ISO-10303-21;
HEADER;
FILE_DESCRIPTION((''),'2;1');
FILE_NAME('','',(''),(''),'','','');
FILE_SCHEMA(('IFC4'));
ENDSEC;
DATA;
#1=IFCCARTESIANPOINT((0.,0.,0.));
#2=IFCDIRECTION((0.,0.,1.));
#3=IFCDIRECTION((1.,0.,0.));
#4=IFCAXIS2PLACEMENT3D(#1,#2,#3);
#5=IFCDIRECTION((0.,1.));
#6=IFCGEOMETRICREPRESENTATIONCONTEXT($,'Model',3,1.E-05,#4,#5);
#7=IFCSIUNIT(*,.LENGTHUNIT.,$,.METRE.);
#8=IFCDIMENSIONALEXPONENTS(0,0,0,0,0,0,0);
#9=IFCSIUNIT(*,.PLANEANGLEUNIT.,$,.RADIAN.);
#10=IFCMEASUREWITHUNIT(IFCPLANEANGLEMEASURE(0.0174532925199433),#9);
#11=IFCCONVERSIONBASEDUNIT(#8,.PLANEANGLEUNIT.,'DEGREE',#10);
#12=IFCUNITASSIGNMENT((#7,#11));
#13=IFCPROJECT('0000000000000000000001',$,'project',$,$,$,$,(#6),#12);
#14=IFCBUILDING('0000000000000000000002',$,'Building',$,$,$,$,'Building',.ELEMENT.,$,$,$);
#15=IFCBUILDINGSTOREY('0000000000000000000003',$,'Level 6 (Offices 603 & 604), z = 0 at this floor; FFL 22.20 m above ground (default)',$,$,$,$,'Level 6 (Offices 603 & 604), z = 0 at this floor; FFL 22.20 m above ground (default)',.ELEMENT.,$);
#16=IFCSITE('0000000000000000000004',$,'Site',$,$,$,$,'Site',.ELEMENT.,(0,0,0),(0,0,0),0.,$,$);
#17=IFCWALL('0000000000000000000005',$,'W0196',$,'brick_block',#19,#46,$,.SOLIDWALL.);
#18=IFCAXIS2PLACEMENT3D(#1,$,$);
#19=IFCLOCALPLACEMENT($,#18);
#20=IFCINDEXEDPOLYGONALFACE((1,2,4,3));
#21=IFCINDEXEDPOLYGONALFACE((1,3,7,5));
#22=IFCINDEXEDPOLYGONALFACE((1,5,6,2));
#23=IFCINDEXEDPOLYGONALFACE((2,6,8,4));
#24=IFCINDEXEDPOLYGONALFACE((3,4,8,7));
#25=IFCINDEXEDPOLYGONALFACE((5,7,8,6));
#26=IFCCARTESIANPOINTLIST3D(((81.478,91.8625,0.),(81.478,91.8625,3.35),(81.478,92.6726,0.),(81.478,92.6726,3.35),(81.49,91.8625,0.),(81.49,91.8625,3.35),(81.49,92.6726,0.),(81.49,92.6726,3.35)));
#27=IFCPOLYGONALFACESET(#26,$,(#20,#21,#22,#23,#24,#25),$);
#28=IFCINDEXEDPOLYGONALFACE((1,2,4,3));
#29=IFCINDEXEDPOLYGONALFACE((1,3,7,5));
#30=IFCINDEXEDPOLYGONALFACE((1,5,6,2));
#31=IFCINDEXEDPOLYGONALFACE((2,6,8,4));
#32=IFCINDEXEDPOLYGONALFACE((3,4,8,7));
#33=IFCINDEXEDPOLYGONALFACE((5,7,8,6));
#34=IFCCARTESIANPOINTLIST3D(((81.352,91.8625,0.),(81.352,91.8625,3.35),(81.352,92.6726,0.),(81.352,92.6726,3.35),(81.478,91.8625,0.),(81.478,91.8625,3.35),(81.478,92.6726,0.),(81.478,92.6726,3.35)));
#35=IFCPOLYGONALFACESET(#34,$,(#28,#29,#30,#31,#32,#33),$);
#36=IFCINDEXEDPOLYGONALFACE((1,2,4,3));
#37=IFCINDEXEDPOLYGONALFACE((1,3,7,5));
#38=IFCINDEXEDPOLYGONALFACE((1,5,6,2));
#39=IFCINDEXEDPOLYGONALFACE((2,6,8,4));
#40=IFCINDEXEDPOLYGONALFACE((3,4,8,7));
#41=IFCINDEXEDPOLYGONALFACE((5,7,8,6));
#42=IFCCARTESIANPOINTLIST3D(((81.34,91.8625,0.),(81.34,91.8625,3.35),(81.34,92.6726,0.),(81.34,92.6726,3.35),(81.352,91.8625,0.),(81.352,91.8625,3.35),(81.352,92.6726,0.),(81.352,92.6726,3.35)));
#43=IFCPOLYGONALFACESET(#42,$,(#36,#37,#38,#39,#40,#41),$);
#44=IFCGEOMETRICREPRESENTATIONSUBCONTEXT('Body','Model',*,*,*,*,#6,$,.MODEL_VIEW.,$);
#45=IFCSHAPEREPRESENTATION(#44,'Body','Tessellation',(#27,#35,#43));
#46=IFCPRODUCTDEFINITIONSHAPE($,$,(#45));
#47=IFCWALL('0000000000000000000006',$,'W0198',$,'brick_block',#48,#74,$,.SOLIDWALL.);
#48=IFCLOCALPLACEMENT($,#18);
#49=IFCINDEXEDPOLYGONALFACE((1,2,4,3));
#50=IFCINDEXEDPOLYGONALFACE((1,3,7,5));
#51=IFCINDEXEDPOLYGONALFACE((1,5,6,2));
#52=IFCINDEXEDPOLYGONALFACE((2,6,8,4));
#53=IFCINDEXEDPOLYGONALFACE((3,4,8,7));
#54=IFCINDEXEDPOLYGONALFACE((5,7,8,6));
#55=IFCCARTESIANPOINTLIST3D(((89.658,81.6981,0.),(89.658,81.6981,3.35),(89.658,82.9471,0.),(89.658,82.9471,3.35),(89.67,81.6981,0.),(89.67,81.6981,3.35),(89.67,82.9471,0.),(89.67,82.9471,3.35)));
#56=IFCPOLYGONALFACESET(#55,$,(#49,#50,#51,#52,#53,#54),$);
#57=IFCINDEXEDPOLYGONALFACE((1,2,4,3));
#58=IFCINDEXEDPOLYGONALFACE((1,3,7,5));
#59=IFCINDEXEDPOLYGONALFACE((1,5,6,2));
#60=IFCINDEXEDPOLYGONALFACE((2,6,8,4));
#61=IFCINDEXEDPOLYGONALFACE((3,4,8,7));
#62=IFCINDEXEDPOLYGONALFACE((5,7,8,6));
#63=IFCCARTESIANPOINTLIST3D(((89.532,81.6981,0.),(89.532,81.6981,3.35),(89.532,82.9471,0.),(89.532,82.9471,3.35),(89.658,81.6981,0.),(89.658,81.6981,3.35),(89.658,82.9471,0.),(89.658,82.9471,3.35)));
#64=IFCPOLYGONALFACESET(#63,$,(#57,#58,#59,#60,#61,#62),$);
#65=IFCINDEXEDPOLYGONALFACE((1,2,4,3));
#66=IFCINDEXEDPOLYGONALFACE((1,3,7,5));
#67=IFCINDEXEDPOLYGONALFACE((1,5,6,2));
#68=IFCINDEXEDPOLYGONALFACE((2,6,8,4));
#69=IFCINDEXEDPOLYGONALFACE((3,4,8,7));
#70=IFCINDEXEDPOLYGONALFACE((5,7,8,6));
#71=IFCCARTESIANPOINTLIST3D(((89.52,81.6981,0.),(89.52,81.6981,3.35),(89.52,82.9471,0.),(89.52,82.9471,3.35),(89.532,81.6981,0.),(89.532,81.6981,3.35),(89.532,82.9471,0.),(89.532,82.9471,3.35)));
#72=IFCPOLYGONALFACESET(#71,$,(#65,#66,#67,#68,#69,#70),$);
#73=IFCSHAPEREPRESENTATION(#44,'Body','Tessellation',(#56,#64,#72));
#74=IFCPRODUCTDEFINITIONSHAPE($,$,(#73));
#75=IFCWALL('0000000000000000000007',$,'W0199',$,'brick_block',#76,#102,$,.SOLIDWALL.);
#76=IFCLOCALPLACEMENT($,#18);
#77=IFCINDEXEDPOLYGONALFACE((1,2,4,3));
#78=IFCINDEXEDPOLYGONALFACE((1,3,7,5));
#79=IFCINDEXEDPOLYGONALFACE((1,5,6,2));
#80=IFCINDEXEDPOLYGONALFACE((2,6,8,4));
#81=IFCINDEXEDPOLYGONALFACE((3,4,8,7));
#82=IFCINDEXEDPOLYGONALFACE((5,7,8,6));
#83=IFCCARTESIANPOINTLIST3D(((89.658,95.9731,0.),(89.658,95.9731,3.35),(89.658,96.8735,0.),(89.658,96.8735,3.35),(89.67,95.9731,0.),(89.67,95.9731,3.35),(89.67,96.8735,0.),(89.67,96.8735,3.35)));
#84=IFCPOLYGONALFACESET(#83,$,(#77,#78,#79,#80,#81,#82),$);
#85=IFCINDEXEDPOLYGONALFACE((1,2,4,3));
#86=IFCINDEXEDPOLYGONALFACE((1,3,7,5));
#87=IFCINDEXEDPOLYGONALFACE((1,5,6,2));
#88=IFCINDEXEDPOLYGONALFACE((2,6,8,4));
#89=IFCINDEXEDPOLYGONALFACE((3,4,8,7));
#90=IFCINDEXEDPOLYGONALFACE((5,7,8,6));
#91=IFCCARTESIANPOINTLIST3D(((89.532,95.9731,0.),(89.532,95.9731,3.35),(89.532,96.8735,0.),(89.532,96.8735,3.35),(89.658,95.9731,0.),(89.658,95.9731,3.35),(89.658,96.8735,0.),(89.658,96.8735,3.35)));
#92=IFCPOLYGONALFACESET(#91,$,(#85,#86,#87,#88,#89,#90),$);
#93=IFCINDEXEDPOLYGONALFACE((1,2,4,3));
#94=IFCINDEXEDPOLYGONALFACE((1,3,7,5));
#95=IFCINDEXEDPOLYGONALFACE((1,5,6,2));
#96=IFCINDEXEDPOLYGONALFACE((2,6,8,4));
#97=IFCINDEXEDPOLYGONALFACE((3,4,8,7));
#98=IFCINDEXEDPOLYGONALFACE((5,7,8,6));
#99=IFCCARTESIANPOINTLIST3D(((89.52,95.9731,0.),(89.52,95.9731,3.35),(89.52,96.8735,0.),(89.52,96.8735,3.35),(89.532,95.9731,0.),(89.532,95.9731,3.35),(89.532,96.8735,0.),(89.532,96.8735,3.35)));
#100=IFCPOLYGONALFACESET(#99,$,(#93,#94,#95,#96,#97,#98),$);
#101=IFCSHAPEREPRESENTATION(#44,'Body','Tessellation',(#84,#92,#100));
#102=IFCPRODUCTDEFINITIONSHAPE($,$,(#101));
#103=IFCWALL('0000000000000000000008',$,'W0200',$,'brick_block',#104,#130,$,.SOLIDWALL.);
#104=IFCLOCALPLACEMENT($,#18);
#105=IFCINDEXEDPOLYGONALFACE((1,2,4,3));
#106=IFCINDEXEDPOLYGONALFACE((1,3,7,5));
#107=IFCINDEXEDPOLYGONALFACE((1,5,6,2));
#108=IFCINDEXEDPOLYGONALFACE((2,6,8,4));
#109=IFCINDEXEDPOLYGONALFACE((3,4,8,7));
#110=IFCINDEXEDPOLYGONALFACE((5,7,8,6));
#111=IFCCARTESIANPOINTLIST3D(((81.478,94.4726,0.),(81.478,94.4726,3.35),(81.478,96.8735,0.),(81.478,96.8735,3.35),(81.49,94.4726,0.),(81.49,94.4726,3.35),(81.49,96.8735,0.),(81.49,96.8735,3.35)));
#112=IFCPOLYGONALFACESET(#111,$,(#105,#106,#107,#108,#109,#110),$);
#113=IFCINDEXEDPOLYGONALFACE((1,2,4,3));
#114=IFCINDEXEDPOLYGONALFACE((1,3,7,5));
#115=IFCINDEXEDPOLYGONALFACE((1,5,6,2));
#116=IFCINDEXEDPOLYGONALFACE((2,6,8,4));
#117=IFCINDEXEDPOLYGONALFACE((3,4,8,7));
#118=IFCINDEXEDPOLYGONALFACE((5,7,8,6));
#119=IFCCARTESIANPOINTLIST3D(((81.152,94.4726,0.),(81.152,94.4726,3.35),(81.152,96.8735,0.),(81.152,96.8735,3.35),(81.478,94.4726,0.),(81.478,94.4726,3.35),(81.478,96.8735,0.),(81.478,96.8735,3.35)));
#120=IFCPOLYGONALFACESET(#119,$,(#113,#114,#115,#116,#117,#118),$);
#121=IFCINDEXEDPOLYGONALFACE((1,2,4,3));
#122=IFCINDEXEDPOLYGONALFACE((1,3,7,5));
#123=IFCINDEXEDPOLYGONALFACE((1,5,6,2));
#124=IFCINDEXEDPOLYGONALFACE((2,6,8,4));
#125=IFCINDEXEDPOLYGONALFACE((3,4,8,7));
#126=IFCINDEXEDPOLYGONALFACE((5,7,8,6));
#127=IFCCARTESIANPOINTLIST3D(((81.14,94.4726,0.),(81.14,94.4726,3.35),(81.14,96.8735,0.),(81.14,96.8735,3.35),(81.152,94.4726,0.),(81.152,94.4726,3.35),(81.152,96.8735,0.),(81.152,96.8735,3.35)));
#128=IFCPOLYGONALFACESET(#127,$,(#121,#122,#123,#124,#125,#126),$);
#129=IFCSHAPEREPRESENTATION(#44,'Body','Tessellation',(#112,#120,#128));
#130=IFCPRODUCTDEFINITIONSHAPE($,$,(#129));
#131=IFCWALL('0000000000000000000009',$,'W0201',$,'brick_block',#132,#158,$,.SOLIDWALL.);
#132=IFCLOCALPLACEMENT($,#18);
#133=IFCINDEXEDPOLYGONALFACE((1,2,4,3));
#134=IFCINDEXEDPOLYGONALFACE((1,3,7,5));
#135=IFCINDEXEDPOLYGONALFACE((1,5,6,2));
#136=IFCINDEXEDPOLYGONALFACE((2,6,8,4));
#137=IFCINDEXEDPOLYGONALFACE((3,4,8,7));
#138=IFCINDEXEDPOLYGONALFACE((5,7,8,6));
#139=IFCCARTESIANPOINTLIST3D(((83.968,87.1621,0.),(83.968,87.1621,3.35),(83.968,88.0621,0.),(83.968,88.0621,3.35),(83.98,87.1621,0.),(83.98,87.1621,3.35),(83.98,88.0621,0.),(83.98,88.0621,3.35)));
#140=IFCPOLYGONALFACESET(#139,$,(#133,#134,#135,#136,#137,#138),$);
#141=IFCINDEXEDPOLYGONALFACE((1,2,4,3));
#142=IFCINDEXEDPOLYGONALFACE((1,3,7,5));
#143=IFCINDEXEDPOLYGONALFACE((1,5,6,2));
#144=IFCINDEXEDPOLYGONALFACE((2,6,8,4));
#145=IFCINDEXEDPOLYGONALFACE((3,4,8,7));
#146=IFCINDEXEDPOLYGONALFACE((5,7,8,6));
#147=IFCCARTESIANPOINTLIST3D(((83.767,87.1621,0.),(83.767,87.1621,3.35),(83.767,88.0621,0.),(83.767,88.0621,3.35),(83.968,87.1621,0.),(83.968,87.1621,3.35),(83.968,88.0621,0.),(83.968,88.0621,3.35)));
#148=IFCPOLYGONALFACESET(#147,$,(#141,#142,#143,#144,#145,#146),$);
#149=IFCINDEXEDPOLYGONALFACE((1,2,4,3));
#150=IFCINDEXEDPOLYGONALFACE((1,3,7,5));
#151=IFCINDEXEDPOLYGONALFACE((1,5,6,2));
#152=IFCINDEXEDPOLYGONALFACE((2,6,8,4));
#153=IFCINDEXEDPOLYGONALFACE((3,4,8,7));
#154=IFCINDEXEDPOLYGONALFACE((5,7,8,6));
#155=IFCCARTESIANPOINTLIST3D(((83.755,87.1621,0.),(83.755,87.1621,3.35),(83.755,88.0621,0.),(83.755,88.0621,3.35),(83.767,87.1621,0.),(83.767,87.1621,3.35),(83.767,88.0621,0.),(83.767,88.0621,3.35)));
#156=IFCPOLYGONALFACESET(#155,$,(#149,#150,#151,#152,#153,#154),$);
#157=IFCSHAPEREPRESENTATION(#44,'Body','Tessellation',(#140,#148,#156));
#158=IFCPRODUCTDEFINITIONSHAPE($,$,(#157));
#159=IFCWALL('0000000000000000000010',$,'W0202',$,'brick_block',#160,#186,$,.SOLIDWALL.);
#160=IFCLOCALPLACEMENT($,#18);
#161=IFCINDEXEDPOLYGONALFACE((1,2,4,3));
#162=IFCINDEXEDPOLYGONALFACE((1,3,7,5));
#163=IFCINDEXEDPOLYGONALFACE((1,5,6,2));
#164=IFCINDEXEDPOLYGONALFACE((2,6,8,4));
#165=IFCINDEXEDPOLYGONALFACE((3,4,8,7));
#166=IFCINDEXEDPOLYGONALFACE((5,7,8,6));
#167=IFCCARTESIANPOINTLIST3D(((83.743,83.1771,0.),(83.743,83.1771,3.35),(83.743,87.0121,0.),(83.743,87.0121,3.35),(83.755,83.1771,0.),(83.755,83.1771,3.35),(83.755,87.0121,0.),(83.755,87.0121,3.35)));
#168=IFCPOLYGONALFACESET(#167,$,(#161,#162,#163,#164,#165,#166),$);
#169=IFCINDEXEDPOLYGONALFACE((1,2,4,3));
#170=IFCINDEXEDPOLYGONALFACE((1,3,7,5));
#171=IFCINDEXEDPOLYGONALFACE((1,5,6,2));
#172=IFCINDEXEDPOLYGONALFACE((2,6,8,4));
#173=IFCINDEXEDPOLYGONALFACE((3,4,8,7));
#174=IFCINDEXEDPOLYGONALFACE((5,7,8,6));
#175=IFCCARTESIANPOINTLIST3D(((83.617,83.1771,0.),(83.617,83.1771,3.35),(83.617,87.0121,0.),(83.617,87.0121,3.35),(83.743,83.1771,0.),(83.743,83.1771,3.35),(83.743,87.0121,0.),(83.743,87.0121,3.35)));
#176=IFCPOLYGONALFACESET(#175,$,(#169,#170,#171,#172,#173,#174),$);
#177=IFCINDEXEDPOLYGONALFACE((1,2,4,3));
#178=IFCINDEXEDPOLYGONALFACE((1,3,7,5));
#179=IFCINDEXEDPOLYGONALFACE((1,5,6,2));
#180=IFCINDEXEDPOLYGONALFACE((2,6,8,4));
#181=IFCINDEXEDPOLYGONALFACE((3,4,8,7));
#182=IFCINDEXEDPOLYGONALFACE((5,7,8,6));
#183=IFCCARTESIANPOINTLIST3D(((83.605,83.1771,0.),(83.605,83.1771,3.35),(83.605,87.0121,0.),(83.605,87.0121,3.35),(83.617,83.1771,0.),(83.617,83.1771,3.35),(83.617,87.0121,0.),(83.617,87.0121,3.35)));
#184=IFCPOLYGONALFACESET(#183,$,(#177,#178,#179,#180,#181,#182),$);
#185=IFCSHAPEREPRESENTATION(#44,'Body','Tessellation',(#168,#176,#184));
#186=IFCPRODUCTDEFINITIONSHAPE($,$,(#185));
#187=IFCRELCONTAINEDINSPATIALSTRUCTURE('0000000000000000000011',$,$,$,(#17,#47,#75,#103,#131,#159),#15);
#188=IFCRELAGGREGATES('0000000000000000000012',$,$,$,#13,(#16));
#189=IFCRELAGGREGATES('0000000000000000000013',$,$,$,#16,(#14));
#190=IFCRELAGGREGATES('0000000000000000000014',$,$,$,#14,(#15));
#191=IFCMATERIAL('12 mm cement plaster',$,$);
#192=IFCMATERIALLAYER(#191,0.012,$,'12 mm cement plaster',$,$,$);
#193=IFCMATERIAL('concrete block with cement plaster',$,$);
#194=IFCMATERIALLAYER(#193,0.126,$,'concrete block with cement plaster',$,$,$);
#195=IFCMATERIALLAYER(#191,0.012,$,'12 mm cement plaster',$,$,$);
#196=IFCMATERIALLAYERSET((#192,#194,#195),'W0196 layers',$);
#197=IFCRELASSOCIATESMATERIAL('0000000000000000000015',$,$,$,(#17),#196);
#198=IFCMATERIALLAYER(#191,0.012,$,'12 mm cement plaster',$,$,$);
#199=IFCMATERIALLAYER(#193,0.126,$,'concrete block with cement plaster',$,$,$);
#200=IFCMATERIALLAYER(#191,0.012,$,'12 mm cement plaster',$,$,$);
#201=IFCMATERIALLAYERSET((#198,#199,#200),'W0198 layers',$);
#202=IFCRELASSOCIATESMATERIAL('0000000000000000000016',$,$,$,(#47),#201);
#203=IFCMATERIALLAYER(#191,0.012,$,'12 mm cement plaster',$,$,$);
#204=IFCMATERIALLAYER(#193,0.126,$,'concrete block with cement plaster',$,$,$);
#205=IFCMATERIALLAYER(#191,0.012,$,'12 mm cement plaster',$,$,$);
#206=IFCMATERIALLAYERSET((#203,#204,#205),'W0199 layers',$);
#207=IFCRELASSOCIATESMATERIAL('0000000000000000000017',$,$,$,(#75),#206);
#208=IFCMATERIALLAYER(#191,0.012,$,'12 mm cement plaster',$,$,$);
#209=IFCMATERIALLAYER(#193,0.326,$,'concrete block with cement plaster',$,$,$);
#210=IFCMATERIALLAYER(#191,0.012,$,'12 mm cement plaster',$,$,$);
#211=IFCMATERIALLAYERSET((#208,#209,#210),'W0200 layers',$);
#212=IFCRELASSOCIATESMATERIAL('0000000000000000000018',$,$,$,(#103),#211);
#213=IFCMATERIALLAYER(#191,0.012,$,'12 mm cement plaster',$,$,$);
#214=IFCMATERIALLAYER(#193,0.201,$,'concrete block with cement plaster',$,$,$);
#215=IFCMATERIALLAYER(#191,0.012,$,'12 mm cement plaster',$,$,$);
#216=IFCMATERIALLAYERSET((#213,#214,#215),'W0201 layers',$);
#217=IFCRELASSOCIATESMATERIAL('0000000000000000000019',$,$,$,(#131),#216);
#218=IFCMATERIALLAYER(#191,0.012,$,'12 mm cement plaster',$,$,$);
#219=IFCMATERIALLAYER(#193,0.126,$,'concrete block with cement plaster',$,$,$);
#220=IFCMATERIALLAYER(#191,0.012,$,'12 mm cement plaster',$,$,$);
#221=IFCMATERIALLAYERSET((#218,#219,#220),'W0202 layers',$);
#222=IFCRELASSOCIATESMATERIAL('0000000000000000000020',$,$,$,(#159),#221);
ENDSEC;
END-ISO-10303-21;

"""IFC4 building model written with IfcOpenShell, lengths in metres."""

from ifc_helpers import new_model, entity, si_unit, converted_unit, direction, frame, frame_2d, origin_with_axes, place, context, subcontext, project, spatial, rectangle, extrude, material, layer, layer_set, layer_usage, element, save


model = new_model("IFC4")

# Units and contexts
model_context = context("Model", 3, precision=1e-05, world=origin_with_axes(), true_north=direction((0.0, 1.0)))
body_context = subcontext(model_context, "Body", "Model", "MODEL_VIEW")
ifc_project = project(units=[si_unit("LENGTHUNIT", "METRE"), converted_unit("PLANEANGLEUNIT", "DEGREE", entity("IfcPlaneAngleMeasure", 0.0174532925199433), si_unit("PLANEANGLEUNIT", "RADIAN"), dimensions=[0, 0, 0, 0, 0, 0, 0])], contexts=[model_context])

# Site, building, storey
site = spatial("IfcSite", under=ifc_project, Name="Site", LongName="Site", CompositionType="ELEMENT", RefLatitude=(0, 0, 0), RefLongitude=(0, 0, 0), RefElevation=0.0)
building = spatial("IfcBuilding", under=site, Name="Building", LongName="Building", CompositionType="ELEMENT")
storey = spatial("IfcBuildingStorey", under=building, Name="Level 6 (Offices 603 & 604), z = 0 at this floor; FFL 22.20 m above ground (default)", LongName="Level 6 (Offices 603 & 604), z = 0 at this floor; FFL 22.20 m above ground (default)", CompositionType="ELEMENT")

# Walls
ifc_material_1 = material(Name="12 mm cement plaster")
ifc_layer_1 = layer(ifc_material_1, 0.012, Name="12 mm cement plaster")
ifc_material_2 = material(Name="concrete block with cement plaster")
ifc_layer_2 = layer(ifc_material_2, 0.126, Name="concrete block with cement plaster")
ifc_layer_3 = layer(ifc_material_1, 0.012, Name="12 mm cement plaster")
ifc_layer_set_1 = layer_set([ifc_layer_1, ifc_layer_2, ifc_layer_3], Name="W0196 layers")
ifc_layer_usage_1 = layer_usage(ifc_layer_set_1, "AXIS2", "POSITIVE", -0.075)
placement = place(None, origin_with_axes())
element("IfcWall", 1, at=placement, inside=storey, material=ifc_layer_usage_1, Name="W0196", ObjectType="brick_block", PredefinedType="SOLIDWALL", context=body_context, shape_type="SweptSolid", body=[
    extrude(rectangle(XDim=0.8101, YDim=0.012, at=frame_2d((0.0, 0.0), x_axis=(0.0, 1.0))), frame((81.484, 92.2675, 0.0), z_axis=(0.0, 0.0, 1.0), x_axis=(1.0, 0.0, 0.0)), (0.0, 0.0, 1.0), 3.35),
    extrude(rectangle(XDim=0.8101, YDim=0.126, at=frame_2d((-0.069, 0.0), x_axis=(0.0, 1.0))), frame((81.484, 92.2675, 0.0), z_axis=(0.0, 0.0, 1.0), x_axis=(1.0, 0.0, 0.0)), (0.0, 0.0, 1.0), 3.35),
    extrude(rectangle(XDim=0.8101, YDim=0.012, at=frame_2d((-0.138, 0.0), x_axis=(0.0, 1.0))), frame((81.484, 92.2675, 0.0), z_axis=(0.0, 0.0, 1.0), x_axis=(1.0, 0.0, 0.0)), (0.0, 0.0, 1.0), 3.35),
])
ifc_layer_4 = layer(ifc_material_1, 0.012, Name="12 mm cement plaster")
ifc_layer_5 = layer(ifc_material_2, 0.126, Name="concrete block with cement plaster")
ifc_layer_6 = layer(ifc_material_1, 0.012, Name="12 mm cement plaster")
ifc_layer_set_2 = layer_set([ifc_layer_4, ifc_layer_5, ifc_layer_6], Name="W0198 layers")
ifc_layer_usage_2 = layer_usage(ifc_layer_set_2, "AXIS2", "POSITIVE", -0.075)
element("IfcWall", 2, at=placement, inside=storey, material=ifc_layer_usage_2, Name="W0198", ObjectType="brick_block", PredefinedType="SOLIDWALL", context=body_context, shape_type="SweptSolid", body=[
    extrude(rectangle(XDim=1.249, YDim=0.012, at=frame_2d((0.0, 0.0), x_axis=(0.0, 1.0))), frame((89.664, 82.3226, 0.0), z_axis=(0.0, 0.0, 1.0), x_axis=(1.0, 0.0, 0.0)), (0.0, 0.0, 1.0), 3.35),
    extrude(rectangle(XDim=1.249, YDim=0.126, at=frame_2d((-0.069, 0.0), x_axis=(0.0, 1.0))), frame((89.664, 82.3226, 0.0), z_axis=(0.0, 0.0, 1.0), x_axis=(1.0, 0.0, 0.0)), (0.0, 0.0, 1.0), 3.35),
    extrude(rectangle(XDim=1.249, YDim=0.012, at=frame_2d((-0.138, 0.0), x_axis=(0.0, 1.0))), frame((89.664, 82.3226, 0.0), z_axis=(0.0, 0.0, 1.0), x_axis=(1.0, 0.0, 0.0)), (0.0, 0.0, 1.0), 3.35),
])
ifc_layer_7 = layer(ifc_material_1, 0.012, Name="12 mm cement plaster")
ifc_layer_8 = layer(ifc_material_2, 0.126, Name="concrete block with cement plaster")
ifc_layer_9 = layer(ifc_material_1, 0.012, Name="12 mm cement plaster")
ifc_layer_set_3 = layer_set([ifc_layer_7, ifc_layer_8, ifc_layer_9], Name="W0199 layers")
ifc_layer_usage_3 = layer_usage(ifc_layer_set_3, "AXIS2", "POSITIVE", -0.075)
element("IfcWall", 3, at=placement, inside=storey, material=ifc_layer_usage_3, Name="W0199", ObjectType="brick_block", PredefinedType="SOLIDWALL", context=body_context, shape_type="SweptSolid", body=[
    extrude(rectangle(XDim=0.9004, YDim=0.012, at=frame_2d((0.0, 0.0), x_axis=(0.0, 1.0))), frame((89.664, 96.4233, 0.0), z_axis=(0.0, 0.0, 1.0), x_axis=(1.0, 0.0, 0.0)), (0.0, 0.0, 1.0), 3.35),
    extrude(rectangle(XDim=0.9004, YDim=0.126, at=frame_2d((-0.069, 0.0), x_axis=(0.0, 1.0))), frame((89.664, 96.4233, 0.0), z_axis=(0.0, 0.0, 1.0), x_axis=(1.0, 0.0, 0.0)), (0.0, 0.0, 1.0), 3.35),
    extrude(rectangle(XDim=0.9004, YDim=0.012, at=frame_2d((-0.138, 0.0), x_axis=(0.0, 1.0))), frame((89.664, 96.4233, 0.0), z_axis=(0.0, 0.0, 1.0), x_axis=(1.0, 0.0, 0.0)), (0.0, 0.0, 1.0), 3.35),
])
ifc_layer_10 = layer(ifc_material_1, 0.012, Name="12 mm cement plaster")
ifc_layer_11 = layer(ifc_material_2, 0.326, Name="concrete block with cement plaster")
ifc_layer_12 = layer(ifc_material_1, 0.012, Name="12 mm cement plaster")
ifc_layer_set_4 = layer_set([ifc_layer_10, ifc_layer_11, ifc_layer_12], Name="W0200 layers")
ifc_layer_usage_4 = layer_usage(ifc_layer_set_4, "AXIS2", "POSITIVE", -0.175)
element("IfcWall", 4, at=placement, inside=storey, material=ifc_layer_usage_4, Name="W0200", ObjectType="brick_block", PredefinedType="SOLIDWALL", context=body_context, shape_type="SweptSolid", body=[
    extrude(rectangle(XDim=2.4009, YDim=0.012, at=frame_2d((0.0, 0.0), x_axis=(0.0, 1.0))), frame((81.484, 95.6731, 0.0), z_axis=(0.0, 0.0, 1.0), x_axis=(1.0, 0.0, 0.0)), (0.0, 0.0, 1.0), 3.35),
    extrude(rectangle(XDim=2.4009, YDim=0.326, at=frame_2d((-0.169, 0.0), x_axis=(0.0, 1.0))), frame((81.484, 95.6731, 0.0), z_axis=(0.0, 0.0, 1.0), x_axis=(1.0, 0.0, 0.0)), (0.0, 0.0, 1.0), 3.35),
    extrude(rectangle(XDim=2.4009, YDim=0.012, at=frame_2d((-0.338, 0.0), x_axis=(0.0, 1.0))), frame((81.484, 95.6731, 0.0), z_axis=(0.0, 0.0, 1.0), x_axis=(1.0, 0.0, 0.0)), (0.0, 0.0, 1.0), 3.35),
])
ifc_layer_13 = layer(ifc_material_1, 0.012, Name="12 mm cement plaster")
ifc_layer_14 = layer(ifc_material_2, 0.201, Name="concrete block with cement plaster")
ifc_layer_15 = layer(ifc_material_1, 0.012, Name="12 mm cement plaster")
ifc_layer_set_5 = layer_set([ifc_layer_13, ifc_layer_14, ifc_layer_15], Name="W0201 layers")
ifc_layer_usage_5 = layer_usage(ifc_layer_set_5, "AXIS2", "POSITIVE", -0.1125)
element("IfcWall", 5, at=placement, inside=storey, material=ifc_layer_usage_5, Name="W0201", ObjectType="brick_block", PredefinedType="SOLIDWALL", context=body_context, shape_type="SweptSolid", body=[
    extrude(rectangle(XDim=0.9, YDim=0.012, at=frame_2d((0.0, 0.0), x_axis=(0.0, 1.0))), frame((83.974, 87.6121, 0.0), z_axis=(0.0, 0.0, 1.0), x_axis=(1.0, 0.0, 0.0)), (0.0, 0.0, 1.0), 3.35),
    extrude(rectangle(XDim=0.9, YDim=0.201, at=frame_2d((-0.1065, 0.0), x_axis=(0.0, 1.0))), frame((83.974, 87.6121, 0.0), z_axis=(0.0, 0.0, 1.0), x_axis=(1.0, 0.0, 0.0)), (0.0, 0.0, 1.0), 3.35),
    extrude(rectangle(XDim=0.9, YDim=0.012, at=frame_2d((-0.213, 0.0), x_axis=(0.0, 1.0))), frame((83.974, 87.6121, 0.0), z_axis=(0.0, 0.0, 1.0), x_axis=(1.0, 0.0, 0.0)), (0.0, 0.0, 1.0), 3.35),
])
ifc_layer_16 = layer(ifc_material_1, 0.012, Name="12 mm cement plaster")
ifc_layer_17 = layer(ifc_material_2, 0.126, Name="concrete block with cement plaster")
ifc_layer_18 = layer(ifc_material_1, 0.012, Name="12 mm cement plaster")
ifc_layer_set_6 = layer_set([ifc_layer_16, ifc_layer_17, ifc_layer_18], Name="W0202 layers")
ifc_layer_usage_6 = layer_usage(ifc_layer_set_6, "AXIS2", "POSITIVE", -0.075)
element("IfcWall", 6, at=placement, inside=storey, material=ifc_layer_usage_6, Name="W0202", ObjectType="brick_block", PredefinedType="SOLIDWALL", context=body_context, shape_type="SweptSolid", body=[
    extrude(rectangle(XDim=3.835, YDim=0.012, at=frame_2d((0.0, 0.0), x_axis=(0.0, 1.0))), frame((83.749, 85.0946, 0.0), z_axis=(0.0, 0.0, 1.0), x_axis=(1.0, 0.0, 0.0)), (0.0, 0.0, 1.0), 3.35),
    extrude(rectangle(XDim=3.835, YDim=0.126, at=frame_2d((-0.069, 0.0), x_axis=(0.0, 1.0))), frame((83.749, 85.0946, 0.0), z_axis=(0.0, 0.0, 1.0), x_axis=(1.0, 0.0, 0.0)), (0.0, 0.0, 1.0), 3.35),
    extrude(rectangle(XDim=3.835, YDim=0.012, at=frame_2d((-0.138, 0.0), x_axis=(0.0, 1.0))), frame((83.749, 85.0946, 0.0), z_axis=(0.0, 0.0, 1.0), x_axis=(1.0, 0.0, 0.0)), (0.0, 0.0, 1.0), 3.35),
])

save(model, "model.ifc")
